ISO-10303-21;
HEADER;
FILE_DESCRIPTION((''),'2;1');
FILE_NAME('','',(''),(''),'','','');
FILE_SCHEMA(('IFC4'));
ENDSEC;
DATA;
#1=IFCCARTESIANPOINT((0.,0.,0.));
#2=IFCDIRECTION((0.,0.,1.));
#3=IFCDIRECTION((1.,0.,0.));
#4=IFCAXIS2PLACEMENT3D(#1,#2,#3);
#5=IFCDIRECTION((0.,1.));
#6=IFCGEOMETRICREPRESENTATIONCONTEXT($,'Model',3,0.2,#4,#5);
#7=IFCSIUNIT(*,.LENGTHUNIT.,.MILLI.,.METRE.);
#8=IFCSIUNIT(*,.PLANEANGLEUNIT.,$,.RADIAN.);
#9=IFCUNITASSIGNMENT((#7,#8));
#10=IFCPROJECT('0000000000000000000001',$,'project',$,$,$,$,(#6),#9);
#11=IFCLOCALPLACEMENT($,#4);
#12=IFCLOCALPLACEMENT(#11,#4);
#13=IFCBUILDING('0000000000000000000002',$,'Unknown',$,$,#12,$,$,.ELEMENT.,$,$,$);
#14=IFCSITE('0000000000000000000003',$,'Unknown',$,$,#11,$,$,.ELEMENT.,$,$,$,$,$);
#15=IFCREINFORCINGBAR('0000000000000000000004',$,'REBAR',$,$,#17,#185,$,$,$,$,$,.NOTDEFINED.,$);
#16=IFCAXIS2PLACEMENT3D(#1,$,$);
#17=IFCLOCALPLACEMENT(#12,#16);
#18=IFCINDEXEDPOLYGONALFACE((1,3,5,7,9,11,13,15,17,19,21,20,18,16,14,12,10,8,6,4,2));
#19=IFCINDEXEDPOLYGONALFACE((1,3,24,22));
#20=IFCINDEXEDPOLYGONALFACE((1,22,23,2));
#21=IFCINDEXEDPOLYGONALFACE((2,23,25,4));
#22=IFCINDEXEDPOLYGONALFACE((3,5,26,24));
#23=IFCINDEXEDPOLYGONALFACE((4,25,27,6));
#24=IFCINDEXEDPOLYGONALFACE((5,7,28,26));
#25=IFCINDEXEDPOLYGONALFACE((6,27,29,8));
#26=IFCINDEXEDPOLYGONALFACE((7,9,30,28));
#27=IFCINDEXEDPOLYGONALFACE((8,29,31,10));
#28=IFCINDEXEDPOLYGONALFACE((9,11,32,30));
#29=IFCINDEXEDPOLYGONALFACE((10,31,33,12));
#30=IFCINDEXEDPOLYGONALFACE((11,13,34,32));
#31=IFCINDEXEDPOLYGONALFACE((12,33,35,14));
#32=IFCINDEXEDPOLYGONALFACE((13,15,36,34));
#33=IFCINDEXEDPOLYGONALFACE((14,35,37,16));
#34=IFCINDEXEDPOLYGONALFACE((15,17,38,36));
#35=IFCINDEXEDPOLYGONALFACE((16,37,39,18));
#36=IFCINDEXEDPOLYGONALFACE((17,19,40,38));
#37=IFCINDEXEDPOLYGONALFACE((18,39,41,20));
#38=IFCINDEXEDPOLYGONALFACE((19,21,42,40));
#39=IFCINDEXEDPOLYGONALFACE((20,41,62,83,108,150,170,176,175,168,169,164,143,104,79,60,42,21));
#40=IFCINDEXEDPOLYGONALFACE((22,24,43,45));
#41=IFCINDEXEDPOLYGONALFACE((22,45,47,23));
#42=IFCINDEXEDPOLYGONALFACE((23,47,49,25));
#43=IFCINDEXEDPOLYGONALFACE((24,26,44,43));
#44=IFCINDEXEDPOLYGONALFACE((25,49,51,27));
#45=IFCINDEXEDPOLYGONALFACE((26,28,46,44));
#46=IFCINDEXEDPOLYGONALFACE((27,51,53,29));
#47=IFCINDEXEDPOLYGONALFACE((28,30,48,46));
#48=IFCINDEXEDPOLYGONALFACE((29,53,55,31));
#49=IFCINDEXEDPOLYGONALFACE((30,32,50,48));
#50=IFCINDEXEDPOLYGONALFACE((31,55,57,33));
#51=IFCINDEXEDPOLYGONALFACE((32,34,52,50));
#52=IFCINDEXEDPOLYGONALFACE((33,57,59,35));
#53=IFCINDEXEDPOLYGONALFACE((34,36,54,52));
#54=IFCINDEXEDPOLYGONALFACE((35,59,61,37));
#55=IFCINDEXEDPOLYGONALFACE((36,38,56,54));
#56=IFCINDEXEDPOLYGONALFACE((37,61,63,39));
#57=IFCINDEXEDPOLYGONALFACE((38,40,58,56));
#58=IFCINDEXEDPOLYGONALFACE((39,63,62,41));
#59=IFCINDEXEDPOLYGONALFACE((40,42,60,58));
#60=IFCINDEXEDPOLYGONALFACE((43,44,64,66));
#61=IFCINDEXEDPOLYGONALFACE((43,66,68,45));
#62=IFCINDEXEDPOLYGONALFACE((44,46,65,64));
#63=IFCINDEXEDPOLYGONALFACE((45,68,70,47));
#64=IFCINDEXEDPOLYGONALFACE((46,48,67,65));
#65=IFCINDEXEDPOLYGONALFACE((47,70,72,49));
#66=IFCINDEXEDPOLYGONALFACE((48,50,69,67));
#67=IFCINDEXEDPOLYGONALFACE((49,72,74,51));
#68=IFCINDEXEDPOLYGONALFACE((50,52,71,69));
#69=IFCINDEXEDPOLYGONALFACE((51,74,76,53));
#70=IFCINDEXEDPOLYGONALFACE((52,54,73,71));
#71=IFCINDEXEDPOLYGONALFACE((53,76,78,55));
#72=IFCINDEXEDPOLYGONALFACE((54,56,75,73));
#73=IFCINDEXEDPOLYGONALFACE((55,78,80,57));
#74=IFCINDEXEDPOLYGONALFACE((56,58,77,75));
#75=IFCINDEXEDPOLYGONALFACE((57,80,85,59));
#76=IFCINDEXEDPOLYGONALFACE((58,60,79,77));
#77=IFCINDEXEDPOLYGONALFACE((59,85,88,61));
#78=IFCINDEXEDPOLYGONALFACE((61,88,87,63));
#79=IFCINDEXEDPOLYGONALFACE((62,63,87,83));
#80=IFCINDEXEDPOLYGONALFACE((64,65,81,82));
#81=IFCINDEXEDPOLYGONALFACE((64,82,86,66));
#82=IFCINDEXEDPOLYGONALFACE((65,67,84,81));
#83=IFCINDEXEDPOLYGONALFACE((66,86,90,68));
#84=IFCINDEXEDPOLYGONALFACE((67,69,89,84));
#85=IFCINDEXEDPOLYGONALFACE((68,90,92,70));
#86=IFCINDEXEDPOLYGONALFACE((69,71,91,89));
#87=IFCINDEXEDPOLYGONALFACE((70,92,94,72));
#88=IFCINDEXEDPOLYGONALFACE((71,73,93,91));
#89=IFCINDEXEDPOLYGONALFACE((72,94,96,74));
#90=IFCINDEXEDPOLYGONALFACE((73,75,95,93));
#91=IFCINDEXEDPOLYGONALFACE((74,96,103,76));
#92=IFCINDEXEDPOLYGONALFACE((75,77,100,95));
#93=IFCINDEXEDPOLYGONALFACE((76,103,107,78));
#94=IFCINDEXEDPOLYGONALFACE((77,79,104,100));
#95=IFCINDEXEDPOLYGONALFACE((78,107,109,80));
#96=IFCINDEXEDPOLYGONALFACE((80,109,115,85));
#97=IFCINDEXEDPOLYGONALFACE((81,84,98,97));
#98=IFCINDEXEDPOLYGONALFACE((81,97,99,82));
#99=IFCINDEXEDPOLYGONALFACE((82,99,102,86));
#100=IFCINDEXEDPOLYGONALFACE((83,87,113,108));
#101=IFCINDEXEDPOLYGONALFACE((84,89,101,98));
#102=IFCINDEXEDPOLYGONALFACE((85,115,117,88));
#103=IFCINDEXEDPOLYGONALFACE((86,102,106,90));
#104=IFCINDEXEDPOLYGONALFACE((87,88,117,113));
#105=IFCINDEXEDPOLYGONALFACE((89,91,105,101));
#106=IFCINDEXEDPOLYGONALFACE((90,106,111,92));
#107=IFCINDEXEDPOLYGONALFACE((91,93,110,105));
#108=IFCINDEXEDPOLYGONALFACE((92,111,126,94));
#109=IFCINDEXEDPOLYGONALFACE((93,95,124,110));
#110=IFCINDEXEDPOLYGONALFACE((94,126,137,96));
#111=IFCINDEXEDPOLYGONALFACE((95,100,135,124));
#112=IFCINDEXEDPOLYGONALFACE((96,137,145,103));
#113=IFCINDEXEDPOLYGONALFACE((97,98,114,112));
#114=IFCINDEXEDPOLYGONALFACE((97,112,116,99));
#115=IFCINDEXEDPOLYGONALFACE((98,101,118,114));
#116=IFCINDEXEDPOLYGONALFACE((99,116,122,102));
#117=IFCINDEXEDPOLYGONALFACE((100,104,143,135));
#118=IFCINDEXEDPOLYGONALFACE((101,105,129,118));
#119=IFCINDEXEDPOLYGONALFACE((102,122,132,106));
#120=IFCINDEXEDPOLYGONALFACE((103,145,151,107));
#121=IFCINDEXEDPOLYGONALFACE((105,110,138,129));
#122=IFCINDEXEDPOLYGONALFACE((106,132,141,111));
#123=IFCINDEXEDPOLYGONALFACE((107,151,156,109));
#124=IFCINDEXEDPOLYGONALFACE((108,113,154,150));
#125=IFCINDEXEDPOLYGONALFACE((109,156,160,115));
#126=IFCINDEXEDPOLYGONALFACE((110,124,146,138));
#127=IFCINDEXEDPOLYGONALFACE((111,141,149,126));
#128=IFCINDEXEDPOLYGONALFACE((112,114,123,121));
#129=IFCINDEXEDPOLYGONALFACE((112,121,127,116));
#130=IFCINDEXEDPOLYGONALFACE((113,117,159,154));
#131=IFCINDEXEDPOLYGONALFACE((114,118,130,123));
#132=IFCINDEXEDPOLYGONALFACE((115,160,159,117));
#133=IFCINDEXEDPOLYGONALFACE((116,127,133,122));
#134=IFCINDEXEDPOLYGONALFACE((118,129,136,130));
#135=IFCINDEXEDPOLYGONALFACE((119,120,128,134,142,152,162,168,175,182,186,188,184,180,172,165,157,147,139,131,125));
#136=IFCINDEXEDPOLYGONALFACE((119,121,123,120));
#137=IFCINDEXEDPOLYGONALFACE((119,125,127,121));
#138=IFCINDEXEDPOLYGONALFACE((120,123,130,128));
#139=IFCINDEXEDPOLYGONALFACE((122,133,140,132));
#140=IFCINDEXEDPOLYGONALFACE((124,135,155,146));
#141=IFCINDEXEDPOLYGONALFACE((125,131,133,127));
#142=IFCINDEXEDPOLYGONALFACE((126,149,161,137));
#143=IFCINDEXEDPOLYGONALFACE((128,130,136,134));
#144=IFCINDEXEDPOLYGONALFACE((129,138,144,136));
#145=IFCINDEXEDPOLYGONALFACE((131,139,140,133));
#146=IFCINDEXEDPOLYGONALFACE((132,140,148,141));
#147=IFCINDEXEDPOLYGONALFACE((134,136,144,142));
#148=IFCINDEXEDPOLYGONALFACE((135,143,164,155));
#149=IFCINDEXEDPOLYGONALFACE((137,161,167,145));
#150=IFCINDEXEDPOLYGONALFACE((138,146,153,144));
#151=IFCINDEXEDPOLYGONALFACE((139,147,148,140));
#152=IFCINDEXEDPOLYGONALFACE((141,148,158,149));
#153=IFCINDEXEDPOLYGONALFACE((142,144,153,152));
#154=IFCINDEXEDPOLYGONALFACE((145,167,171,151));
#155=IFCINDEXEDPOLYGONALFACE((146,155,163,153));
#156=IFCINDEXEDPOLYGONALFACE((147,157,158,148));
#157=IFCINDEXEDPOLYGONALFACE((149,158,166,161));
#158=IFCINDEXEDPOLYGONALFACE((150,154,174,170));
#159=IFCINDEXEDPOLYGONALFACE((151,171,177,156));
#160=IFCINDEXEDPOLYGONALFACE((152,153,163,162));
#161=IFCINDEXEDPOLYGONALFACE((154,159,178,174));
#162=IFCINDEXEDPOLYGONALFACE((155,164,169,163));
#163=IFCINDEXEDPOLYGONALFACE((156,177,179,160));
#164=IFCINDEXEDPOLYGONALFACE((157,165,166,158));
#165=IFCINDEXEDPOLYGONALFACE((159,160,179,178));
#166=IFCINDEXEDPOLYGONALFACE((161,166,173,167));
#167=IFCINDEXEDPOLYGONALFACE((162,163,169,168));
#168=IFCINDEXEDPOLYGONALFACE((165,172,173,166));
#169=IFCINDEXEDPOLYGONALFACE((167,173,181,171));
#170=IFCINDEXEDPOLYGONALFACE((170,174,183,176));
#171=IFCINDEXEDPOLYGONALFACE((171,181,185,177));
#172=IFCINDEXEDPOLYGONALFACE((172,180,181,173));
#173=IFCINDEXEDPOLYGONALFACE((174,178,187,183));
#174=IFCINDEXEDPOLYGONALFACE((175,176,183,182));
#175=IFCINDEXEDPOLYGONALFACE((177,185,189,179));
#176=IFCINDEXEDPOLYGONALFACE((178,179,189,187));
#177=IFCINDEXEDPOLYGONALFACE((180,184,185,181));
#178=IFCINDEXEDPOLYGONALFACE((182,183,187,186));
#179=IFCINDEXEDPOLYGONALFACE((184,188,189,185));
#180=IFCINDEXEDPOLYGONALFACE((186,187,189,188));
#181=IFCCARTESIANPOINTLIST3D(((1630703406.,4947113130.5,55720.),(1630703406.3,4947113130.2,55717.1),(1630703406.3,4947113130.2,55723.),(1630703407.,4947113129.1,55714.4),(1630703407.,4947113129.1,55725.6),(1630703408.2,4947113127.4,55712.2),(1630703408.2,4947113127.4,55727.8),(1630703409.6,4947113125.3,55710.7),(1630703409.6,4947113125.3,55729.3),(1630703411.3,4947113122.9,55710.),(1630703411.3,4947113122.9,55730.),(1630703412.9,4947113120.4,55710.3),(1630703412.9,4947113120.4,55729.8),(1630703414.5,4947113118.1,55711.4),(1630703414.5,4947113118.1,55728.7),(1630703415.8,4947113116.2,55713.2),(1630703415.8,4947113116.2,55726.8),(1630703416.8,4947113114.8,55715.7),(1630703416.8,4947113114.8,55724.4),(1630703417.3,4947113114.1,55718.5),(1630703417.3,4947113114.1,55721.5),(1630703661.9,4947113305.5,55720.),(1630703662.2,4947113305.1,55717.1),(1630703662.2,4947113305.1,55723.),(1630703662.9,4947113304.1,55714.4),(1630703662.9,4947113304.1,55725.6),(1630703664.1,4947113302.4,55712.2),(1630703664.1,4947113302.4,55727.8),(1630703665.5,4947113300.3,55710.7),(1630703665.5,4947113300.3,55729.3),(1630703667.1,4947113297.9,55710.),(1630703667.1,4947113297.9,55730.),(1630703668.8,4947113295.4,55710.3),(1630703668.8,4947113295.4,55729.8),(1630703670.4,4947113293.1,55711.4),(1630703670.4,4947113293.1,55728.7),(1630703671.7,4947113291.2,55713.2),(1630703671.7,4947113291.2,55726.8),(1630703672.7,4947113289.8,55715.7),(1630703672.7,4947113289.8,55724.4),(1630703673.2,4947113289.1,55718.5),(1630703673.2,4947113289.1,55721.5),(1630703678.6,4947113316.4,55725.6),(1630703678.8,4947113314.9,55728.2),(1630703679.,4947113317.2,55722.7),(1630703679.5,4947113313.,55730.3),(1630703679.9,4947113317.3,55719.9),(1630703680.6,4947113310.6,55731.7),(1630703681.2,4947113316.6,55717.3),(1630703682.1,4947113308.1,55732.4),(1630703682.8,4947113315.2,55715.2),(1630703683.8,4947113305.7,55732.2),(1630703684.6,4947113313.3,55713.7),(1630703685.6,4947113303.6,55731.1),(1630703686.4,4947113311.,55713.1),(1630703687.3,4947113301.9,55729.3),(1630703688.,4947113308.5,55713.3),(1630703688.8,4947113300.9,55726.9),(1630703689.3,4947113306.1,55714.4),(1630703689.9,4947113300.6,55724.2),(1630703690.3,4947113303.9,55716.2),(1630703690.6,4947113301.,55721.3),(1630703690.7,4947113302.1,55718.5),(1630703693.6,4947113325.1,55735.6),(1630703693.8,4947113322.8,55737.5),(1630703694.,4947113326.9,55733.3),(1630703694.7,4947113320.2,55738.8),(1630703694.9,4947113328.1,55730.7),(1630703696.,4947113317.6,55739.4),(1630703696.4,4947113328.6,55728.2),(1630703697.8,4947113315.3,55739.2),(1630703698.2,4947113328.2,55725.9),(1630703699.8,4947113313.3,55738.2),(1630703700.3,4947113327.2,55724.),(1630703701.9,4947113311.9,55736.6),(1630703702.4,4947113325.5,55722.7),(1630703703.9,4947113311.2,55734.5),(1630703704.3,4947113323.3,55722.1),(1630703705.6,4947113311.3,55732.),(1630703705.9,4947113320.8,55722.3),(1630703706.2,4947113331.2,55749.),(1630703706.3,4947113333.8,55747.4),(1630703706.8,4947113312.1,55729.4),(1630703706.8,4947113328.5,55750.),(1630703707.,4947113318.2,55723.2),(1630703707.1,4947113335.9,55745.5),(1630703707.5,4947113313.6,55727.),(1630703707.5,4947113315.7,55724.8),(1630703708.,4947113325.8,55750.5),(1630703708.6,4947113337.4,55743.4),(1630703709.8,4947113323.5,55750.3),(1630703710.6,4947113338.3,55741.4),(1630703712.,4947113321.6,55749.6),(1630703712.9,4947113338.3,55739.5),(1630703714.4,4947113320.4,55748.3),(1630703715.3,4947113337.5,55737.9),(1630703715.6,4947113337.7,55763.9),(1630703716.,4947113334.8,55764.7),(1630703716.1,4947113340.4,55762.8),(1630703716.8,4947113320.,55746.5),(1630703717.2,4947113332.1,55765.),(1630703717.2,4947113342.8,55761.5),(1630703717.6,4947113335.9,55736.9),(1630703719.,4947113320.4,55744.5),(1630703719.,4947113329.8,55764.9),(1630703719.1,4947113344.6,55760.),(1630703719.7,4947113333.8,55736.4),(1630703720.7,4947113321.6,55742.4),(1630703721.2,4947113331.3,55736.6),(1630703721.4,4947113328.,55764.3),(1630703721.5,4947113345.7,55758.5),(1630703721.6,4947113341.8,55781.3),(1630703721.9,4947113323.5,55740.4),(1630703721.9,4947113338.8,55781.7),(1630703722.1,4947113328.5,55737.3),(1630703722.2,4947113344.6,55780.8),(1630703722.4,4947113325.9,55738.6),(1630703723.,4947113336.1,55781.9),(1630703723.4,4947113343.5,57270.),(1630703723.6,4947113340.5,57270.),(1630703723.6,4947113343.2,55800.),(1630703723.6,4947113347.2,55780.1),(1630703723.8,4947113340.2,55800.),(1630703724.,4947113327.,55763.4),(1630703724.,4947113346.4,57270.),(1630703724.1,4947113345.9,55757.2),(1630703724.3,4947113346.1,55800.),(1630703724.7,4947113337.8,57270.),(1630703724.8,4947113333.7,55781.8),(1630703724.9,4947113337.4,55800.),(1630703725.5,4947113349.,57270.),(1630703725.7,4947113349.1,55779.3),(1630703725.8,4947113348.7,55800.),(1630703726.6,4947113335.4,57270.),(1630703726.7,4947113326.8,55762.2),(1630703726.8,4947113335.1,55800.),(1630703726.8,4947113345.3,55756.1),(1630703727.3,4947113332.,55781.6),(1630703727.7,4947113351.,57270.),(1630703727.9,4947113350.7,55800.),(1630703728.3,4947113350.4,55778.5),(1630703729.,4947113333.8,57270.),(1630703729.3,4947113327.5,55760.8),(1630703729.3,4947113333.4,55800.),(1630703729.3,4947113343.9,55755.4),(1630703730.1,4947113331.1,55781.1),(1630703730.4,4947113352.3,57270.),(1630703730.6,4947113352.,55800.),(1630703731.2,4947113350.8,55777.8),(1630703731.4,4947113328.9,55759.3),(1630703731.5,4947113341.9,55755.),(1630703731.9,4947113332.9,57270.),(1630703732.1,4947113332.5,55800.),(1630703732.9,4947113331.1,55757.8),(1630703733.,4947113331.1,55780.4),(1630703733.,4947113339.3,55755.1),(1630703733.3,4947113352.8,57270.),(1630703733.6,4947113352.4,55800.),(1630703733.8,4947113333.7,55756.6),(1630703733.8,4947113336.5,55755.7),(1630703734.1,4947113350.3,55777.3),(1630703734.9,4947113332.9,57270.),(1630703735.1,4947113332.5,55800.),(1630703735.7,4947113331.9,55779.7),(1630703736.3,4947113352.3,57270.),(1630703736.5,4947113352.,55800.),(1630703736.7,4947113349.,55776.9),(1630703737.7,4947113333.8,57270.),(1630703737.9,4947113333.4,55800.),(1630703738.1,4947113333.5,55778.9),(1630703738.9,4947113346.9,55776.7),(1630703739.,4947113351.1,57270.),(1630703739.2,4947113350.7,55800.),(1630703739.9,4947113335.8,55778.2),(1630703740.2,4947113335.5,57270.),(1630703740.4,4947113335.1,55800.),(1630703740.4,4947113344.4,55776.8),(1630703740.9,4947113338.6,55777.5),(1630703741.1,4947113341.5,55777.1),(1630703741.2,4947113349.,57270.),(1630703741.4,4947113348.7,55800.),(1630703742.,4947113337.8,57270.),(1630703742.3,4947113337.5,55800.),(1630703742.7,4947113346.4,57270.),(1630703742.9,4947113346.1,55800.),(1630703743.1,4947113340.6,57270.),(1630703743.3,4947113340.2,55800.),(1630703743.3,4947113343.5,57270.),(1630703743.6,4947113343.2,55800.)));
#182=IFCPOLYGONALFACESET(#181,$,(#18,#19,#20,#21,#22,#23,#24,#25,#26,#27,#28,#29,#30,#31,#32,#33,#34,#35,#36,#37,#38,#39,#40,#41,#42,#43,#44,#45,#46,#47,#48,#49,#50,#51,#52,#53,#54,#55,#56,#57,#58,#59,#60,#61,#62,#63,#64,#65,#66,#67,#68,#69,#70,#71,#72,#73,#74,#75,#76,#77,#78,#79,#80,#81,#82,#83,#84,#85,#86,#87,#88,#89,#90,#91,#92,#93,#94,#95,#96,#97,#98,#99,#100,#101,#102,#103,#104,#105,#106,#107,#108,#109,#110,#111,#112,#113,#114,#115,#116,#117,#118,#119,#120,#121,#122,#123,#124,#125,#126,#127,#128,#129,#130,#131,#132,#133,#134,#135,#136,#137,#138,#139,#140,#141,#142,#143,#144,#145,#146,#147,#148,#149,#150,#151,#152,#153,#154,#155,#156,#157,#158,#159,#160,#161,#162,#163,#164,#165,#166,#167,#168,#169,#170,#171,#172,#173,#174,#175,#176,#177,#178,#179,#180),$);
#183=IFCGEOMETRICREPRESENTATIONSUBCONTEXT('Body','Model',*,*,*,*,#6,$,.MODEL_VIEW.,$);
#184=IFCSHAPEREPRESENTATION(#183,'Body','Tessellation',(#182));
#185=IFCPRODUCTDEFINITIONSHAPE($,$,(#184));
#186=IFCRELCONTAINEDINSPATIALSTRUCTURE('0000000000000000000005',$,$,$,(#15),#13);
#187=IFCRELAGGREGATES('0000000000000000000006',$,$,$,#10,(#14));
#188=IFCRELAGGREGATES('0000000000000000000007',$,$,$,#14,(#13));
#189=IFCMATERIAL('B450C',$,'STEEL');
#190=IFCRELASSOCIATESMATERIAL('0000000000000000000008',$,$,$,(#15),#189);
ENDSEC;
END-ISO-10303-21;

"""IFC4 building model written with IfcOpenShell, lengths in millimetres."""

from ifc_helpers import new_model, entity, si_unit, direction, frame, origin_with_axes, place, context, subcontext, project, spatial, material, element, save


model = new_model("IFC4")

# Units and contexts
model_context = context("Model", 3, precision=0.2, world=origin_with_axes(), true_north=direction((0.0, 1.0)))
body_context = subcontext(model_context, "Body", "Model", "MODEL_VIEW")
ifc_project = project(units=[si_unit("LENGTHUNIT", "METRE", prefix="MILLI"), si_unit("PLANEANGLEUNIT", "RADIAN")], contexts=[model_context])

# Site, building
site_placement = place(None, origin_with_axes())
site = spatial("IfcSite", under=ifc_project, at=site_placement, Name="Unknown", CompositionType="ELEMENT")
building_placement = place(site_placement, origin_with_axes())
building = spatial("IfcBuilding", under=site, at=building_placement, Name="Unknown", CompositionType="ELEMENT")

# Reinforcing bar
ifc_material = material(Name="B450C", Category="STEEL")
reinforcing_bar_1_placement = place(building_placement, frame((1630703746.7, 4947113411.9, 55670.0), z_axis=(0.564492, -0.825439, 0.0), x_axis=(0.0, 0.0, 1.0)))
element("IfcReinforcingBar", 1, at=reinforcing_bar_1_placement, inside=building, material=ifc_material, Name="REBAR", PredefinedType="NOTDEFINED", context=body_context, shape_type="AdvancedSweptSolid", body=[
    entity("IfcSweptDiskSolid", entity("IfcIndexedPolyCurve", entity("IfcCartesianPointList3D", [[50.0, 440.0, 50.0], [50.0, 130.0, 50.0], [73.4, 73.4, 50.0], [130.0, 50.0, 50.0], [1600.0, 50.0, 49.5]]), [entity("IfcLineIndex", [1, 2]), entity("IfcArcIndex", [2, 3, 4]), entity("IfcLineIndex", [4, 5])]), 10.0),
])

save(model, "model.ifc")
